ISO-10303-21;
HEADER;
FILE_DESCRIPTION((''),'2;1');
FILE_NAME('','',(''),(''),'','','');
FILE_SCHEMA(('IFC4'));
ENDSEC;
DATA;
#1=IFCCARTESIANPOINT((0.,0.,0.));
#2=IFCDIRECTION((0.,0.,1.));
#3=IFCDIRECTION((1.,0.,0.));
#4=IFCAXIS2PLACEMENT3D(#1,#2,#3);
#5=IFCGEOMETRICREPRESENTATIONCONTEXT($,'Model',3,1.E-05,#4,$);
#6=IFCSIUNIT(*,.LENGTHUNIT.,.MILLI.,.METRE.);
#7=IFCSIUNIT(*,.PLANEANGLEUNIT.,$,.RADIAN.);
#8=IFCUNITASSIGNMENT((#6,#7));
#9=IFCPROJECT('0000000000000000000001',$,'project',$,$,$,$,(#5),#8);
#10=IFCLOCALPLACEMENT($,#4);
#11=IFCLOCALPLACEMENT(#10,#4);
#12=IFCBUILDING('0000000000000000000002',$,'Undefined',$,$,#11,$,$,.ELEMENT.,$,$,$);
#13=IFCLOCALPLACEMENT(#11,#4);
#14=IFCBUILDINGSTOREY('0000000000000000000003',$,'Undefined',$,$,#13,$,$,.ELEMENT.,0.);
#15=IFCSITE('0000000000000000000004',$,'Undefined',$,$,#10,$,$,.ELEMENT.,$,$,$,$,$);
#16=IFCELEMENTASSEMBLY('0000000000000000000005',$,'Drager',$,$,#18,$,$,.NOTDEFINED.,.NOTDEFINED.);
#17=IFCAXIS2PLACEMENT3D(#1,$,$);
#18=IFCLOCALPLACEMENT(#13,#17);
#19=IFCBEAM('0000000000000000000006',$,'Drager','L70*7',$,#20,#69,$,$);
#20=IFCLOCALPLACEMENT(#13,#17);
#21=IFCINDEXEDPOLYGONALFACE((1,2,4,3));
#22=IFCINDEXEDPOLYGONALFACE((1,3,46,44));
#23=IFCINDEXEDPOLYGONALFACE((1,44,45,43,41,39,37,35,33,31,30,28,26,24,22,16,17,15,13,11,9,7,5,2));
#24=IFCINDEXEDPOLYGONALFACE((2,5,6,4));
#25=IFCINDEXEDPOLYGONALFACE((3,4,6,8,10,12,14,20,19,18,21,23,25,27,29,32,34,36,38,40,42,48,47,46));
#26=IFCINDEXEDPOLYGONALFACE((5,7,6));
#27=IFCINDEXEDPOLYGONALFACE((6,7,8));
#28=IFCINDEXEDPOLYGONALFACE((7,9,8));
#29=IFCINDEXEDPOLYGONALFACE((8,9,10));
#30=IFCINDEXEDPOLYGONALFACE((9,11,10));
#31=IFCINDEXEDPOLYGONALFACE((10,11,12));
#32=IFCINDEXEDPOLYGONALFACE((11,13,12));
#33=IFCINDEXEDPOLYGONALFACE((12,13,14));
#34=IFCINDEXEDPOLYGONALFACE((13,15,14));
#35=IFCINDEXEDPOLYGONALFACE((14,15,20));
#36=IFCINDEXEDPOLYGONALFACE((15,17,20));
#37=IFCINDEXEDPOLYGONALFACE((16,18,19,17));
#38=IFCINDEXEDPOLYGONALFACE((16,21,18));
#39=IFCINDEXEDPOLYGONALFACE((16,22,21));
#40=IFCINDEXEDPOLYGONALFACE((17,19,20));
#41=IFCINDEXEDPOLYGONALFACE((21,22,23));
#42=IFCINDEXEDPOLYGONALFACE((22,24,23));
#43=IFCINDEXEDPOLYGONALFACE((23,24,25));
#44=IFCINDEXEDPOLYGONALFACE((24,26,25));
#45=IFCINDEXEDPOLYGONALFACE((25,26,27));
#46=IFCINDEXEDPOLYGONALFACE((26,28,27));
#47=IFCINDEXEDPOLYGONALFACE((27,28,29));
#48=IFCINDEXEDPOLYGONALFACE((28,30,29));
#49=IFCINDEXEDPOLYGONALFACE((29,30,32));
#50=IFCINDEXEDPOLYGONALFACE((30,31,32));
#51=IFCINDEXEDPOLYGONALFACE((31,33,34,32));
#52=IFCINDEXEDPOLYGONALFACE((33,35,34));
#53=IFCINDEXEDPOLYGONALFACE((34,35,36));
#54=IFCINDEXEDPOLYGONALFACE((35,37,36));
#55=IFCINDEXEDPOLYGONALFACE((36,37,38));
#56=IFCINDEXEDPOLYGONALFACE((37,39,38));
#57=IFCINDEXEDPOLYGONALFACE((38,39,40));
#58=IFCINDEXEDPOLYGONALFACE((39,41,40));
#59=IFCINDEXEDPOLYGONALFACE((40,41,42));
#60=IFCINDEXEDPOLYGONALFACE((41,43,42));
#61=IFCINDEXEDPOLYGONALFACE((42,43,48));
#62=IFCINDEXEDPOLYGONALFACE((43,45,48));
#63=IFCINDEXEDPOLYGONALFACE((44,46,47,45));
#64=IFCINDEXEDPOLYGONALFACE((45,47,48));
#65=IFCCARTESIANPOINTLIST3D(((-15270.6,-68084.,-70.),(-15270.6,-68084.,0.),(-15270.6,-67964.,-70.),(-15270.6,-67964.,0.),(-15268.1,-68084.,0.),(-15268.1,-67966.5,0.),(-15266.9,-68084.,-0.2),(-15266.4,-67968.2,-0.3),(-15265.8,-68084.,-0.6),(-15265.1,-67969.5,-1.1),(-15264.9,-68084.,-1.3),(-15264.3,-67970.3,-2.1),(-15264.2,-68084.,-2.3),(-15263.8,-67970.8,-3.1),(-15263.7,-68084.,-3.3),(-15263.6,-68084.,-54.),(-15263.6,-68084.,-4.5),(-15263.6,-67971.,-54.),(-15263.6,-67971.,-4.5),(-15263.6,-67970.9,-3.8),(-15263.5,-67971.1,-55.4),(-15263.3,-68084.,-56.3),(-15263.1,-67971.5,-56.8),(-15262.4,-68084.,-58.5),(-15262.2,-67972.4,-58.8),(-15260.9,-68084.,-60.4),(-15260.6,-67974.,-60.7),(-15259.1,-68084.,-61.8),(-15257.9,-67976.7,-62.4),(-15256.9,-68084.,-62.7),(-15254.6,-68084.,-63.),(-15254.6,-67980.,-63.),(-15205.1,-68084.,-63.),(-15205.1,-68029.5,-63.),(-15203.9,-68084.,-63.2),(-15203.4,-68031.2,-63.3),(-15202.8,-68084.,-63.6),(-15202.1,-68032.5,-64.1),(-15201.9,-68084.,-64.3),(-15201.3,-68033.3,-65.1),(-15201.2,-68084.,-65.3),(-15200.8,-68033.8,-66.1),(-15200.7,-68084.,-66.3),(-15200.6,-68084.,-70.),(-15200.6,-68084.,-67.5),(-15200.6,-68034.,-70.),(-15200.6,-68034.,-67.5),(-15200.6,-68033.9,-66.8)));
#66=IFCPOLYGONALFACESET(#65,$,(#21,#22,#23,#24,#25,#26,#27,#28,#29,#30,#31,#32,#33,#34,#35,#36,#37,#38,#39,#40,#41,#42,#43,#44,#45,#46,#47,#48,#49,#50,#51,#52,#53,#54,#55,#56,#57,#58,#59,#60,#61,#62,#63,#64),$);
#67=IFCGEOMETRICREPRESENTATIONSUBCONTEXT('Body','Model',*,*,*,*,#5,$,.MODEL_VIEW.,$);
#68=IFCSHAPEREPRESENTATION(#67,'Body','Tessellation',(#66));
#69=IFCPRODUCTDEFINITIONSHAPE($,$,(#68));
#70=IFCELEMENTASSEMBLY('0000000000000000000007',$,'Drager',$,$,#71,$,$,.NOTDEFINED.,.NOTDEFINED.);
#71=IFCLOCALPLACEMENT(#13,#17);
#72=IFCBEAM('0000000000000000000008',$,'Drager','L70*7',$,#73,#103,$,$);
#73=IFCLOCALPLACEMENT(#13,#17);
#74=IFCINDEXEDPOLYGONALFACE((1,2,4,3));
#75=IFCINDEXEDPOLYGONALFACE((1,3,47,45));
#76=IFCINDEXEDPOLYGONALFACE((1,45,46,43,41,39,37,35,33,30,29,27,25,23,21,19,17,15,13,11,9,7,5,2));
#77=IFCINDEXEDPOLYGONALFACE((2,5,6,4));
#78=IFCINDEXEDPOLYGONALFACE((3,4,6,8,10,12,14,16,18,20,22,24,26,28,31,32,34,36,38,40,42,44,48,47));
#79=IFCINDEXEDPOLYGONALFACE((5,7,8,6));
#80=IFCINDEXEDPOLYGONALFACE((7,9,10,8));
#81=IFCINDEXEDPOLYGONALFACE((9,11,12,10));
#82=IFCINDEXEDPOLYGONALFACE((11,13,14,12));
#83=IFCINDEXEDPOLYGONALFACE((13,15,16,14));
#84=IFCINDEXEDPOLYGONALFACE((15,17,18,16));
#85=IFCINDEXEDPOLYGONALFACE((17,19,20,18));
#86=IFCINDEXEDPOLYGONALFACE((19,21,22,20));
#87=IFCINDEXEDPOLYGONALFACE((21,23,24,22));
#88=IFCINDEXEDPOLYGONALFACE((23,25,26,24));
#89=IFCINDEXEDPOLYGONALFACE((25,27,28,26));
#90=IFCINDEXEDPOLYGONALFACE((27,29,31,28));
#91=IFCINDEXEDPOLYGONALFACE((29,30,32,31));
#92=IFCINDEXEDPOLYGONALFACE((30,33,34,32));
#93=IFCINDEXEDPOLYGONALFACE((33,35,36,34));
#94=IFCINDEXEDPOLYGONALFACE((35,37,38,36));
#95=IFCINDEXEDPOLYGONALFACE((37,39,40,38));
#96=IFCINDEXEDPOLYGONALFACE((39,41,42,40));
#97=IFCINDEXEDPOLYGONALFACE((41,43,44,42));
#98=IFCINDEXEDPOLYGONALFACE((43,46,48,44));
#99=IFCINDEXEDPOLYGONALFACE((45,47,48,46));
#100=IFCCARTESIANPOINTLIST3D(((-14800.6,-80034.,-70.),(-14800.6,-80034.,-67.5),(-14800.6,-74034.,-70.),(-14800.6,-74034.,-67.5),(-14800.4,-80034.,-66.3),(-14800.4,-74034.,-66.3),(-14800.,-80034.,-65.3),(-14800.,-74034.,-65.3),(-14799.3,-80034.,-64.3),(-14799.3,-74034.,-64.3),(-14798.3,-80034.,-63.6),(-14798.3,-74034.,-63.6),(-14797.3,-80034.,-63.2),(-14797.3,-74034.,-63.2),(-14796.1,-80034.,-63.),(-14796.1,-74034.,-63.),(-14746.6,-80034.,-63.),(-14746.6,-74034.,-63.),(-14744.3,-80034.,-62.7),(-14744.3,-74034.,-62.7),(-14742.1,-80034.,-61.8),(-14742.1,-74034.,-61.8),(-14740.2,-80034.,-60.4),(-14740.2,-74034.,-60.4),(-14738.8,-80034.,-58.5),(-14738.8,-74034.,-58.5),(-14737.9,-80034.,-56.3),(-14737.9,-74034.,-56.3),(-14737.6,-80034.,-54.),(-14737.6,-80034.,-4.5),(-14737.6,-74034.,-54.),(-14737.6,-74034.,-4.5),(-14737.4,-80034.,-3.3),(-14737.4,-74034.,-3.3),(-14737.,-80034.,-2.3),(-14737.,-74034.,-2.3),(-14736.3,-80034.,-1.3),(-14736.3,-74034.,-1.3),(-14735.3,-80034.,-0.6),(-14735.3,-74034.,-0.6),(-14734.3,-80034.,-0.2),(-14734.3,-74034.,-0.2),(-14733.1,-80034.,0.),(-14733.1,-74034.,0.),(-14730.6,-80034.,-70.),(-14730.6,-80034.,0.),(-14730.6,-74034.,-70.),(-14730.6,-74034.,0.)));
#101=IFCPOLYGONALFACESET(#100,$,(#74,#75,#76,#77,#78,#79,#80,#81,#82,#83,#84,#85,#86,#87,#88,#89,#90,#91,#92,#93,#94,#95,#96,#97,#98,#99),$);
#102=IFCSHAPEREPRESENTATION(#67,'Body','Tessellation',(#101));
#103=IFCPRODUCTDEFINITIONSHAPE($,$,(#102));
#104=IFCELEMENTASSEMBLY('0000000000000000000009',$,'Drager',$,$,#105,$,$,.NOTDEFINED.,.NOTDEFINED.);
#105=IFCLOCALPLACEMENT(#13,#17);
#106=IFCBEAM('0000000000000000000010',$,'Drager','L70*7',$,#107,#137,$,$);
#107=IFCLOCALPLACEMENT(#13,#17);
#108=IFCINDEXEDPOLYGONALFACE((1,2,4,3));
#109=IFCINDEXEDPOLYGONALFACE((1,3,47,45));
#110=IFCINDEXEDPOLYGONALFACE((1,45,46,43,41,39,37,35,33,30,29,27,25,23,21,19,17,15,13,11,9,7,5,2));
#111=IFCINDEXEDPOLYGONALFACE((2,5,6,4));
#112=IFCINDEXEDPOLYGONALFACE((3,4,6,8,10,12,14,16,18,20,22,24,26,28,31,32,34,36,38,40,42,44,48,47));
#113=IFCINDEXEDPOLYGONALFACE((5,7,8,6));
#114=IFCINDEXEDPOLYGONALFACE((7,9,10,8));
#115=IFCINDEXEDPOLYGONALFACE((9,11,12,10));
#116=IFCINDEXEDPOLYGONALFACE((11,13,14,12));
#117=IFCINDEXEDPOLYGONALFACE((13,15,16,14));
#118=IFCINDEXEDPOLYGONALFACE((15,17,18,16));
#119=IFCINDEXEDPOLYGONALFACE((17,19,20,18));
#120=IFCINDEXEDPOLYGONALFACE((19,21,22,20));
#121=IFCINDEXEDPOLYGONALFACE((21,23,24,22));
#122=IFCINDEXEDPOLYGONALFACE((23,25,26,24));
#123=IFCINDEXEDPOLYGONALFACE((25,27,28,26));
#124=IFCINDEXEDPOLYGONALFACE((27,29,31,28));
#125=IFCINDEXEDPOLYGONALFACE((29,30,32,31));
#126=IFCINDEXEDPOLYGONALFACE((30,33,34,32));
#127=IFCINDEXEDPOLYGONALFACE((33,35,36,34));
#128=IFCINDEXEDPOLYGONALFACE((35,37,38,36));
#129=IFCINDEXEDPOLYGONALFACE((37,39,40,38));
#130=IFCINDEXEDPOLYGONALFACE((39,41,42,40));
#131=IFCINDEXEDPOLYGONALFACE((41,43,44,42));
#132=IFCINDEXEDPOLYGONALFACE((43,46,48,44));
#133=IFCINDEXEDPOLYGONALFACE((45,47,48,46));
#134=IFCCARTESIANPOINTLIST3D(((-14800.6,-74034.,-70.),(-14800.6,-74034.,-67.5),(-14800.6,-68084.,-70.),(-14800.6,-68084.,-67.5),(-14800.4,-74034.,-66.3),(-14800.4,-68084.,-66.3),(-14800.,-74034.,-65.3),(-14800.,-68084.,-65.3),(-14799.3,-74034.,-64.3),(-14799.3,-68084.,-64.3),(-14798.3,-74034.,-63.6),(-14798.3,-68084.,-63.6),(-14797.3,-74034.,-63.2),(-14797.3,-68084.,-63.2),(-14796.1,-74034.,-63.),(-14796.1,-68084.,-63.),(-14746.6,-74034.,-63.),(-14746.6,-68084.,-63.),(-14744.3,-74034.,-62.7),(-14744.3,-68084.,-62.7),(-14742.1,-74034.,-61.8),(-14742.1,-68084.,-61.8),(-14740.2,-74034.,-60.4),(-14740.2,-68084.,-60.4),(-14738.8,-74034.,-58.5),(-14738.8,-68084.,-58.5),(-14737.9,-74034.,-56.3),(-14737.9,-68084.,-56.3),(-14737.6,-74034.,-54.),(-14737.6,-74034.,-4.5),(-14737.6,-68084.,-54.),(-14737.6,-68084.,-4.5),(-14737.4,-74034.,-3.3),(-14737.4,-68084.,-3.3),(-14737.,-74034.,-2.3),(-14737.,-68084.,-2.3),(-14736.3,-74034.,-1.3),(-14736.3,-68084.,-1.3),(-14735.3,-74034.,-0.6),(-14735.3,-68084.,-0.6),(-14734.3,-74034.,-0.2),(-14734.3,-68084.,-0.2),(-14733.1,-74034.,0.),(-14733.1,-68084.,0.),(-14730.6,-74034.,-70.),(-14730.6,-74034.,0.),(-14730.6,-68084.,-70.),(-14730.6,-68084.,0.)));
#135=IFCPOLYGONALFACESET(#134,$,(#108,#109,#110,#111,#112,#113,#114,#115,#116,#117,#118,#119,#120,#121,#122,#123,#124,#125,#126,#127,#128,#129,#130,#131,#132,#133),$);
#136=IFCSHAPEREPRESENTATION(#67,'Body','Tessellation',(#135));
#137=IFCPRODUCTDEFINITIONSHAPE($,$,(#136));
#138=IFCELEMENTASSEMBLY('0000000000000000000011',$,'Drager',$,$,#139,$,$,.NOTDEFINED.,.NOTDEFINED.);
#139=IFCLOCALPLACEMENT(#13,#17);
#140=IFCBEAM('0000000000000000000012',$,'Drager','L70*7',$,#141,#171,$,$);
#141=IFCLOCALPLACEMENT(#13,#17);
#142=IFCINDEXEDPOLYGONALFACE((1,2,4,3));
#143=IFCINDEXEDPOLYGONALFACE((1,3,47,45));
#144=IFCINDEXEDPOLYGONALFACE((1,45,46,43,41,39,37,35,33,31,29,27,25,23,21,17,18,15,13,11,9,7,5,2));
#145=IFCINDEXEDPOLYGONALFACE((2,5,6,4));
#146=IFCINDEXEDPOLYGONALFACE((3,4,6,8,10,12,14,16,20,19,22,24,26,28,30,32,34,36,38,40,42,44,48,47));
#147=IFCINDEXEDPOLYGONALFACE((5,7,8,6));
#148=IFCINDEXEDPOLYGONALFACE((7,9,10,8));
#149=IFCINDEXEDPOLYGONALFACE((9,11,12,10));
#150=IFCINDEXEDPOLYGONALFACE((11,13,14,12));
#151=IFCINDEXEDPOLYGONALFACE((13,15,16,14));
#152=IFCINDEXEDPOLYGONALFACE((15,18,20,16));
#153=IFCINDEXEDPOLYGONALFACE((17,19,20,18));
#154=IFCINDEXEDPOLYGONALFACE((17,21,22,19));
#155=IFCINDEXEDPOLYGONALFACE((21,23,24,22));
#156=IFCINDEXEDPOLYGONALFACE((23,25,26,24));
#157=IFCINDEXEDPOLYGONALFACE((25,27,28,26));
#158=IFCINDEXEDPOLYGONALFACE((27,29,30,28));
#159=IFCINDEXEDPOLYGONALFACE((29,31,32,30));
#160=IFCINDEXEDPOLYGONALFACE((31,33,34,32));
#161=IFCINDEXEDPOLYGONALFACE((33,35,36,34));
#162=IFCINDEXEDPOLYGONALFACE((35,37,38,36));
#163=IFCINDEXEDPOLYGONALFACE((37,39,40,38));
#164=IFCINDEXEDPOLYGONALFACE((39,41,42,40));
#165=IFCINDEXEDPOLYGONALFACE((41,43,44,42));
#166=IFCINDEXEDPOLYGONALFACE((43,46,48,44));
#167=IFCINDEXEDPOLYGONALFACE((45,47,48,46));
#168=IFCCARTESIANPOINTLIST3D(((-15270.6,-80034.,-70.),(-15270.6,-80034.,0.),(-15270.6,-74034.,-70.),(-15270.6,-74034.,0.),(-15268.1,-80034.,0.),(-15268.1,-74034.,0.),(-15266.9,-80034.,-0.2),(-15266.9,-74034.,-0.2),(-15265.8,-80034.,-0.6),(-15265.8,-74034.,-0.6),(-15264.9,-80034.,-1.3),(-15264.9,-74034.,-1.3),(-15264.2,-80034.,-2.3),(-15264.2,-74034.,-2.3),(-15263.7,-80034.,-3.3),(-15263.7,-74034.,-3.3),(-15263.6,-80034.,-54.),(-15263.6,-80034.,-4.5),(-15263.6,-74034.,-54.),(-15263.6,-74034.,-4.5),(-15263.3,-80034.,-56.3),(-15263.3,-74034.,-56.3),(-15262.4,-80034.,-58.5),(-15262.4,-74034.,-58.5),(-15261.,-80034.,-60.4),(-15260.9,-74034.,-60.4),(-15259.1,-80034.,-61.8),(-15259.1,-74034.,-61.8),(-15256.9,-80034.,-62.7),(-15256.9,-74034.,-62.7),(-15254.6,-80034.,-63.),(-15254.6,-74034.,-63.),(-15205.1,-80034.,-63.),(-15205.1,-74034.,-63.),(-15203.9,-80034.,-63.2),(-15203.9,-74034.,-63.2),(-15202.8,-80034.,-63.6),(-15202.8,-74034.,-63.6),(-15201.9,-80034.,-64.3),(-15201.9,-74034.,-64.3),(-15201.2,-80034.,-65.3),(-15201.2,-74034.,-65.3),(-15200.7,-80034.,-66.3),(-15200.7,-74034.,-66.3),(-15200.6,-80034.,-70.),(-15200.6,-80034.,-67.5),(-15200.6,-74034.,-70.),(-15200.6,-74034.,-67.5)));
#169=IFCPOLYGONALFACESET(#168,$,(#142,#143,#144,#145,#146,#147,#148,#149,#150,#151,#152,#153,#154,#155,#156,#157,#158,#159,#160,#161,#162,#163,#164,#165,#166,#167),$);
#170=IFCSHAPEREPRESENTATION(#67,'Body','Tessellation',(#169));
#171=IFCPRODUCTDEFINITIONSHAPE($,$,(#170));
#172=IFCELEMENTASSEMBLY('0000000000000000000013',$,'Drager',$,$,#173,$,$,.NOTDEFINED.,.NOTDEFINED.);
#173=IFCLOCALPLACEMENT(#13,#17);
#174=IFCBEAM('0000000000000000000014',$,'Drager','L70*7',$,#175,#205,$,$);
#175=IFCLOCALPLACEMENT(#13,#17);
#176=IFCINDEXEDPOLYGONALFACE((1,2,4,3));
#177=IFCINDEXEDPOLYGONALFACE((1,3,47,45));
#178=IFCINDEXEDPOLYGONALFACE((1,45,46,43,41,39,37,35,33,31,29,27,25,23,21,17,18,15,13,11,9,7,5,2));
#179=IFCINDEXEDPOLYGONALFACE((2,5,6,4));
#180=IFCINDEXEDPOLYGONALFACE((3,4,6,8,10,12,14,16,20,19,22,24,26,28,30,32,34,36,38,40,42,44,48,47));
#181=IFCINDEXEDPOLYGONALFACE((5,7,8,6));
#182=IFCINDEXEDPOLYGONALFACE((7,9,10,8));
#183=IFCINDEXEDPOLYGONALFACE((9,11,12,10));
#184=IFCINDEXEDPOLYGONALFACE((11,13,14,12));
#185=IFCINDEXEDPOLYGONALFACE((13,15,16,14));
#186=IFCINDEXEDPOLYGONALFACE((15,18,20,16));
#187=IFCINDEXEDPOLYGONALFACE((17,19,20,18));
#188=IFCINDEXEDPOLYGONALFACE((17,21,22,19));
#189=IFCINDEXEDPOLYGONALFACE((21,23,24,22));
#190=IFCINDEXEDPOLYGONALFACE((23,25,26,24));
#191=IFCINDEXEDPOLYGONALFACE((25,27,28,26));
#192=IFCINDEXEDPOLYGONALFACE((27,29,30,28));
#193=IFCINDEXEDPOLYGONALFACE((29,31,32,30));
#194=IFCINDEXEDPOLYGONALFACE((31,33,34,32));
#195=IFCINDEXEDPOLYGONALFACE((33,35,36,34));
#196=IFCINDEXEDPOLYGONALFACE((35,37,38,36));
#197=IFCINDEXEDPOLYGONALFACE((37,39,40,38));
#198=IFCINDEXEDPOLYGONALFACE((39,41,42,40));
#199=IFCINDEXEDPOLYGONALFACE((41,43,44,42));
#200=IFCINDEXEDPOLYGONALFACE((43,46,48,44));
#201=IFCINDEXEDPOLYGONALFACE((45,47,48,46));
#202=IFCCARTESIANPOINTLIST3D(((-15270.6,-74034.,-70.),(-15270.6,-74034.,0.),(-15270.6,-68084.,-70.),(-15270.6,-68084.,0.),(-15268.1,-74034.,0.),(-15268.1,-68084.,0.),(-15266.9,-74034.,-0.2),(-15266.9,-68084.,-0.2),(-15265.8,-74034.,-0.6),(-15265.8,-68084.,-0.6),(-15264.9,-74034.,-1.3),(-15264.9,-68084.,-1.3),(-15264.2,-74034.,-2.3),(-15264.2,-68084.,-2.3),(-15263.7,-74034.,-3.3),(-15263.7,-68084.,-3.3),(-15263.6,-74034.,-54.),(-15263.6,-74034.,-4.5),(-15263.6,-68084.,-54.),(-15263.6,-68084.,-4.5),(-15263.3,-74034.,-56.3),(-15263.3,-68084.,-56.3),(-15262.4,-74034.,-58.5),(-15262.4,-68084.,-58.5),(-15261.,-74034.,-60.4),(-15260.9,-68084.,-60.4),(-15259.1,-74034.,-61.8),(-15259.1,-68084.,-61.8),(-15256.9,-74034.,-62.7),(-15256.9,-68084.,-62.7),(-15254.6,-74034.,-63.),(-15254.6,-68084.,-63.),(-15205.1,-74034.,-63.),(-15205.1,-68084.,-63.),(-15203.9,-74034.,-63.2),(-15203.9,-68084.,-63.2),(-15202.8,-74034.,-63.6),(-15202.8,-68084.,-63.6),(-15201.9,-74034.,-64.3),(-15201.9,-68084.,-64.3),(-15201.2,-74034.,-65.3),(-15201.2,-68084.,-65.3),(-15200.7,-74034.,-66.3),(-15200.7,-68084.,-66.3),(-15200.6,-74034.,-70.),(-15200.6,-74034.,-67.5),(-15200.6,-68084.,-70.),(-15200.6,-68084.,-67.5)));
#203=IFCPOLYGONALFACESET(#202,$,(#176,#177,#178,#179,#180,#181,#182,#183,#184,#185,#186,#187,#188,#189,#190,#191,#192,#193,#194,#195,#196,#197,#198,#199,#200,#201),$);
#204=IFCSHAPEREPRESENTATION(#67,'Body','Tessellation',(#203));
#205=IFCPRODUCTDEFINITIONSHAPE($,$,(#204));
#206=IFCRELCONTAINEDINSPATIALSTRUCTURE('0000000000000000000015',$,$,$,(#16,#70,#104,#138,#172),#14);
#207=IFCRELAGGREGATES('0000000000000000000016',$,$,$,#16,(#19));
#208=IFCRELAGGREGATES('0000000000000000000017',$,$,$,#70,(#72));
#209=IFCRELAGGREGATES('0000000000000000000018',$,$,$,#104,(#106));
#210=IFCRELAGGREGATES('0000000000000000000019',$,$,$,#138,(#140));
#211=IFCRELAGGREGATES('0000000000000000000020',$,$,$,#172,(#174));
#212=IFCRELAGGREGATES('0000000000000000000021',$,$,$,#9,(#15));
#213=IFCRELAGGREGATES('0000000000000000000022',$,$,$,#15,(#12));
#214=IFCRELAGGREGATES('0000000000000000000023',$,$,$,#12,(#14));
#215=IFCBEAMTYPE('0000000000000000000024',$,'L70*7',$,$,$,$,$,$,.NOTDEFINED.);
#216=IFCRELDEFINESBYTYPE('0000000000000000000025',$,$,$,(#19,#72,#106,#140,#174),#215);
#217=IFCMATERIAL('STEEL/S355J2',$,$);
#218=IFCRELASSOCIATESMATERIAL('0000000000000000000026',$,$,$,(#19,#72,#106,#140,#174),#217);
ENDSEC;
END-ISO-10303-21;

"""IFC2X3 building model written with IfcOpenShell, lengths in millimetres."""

from ifc_helpers import new_model, si_unit, frame, origin_with_axes, origin_2d_with_axis, place, context, subcontext, project, spatial, l_section, extrude, clip, halfspace, material, type_object, element, aggregate, save


model = new_model("IFC2X3")

# Units and contexts
model_context = context("Model", 3, precision=1e-05, world=origin_with_axes())
body_context = subcontext(model_context, "Body", "Model", "MODEL_VIEW")
ifc_project = project(units=[si_unit("LENGTHUNIT", "METRE", prefix="MILLI"), si_unit("PLANEANGLEUNIT", "RADIAN")], contexts=[model_context])

# Site, building, storey
site_placement = place(None, origin_with_axes())
site = spatial("IfcSite", under=ifc_project, at=site_placement, Name="Undefined", CompositionType="ELEMENT")
building_placement = place(site_placement, origin_with_axes())
building = spatial("IfcBuilding", under=site, at=building_placement, Name="Undefined", CompositionType="ELEMENT")
storey_placement = place(building_placement, origin_with_axes())
storey = spatial("IfcBuildingStorey", under=building, at=storey_placement, Name="Undefined", CompositionType="ELEMENT", Elevation=0.0)

# Shared definitions
ifc_material = material(Name="STEEL/S355J2")
beam_type = type_object("IfcBeamType", Name="L70*7", PredefinedType="NOTDEFINED")

# Element assembly, beam
assembly_1_placement = place(storey_placement, origin_with_axes())
assembly_1 = element("IfcElementAssembly", 1, at=assembly_1_placement, inside=storey, Name="Drager", AssemblyPlace="NOTDEFINED", PredefinedType="NOTDEFINED")
beam_1_placement = place(assembly_1_placement, frame((-15235.6, -68084.0, -35.0), z_axis=(0.0, 0.0, 1.0), x_axis=(0.0, 1.0, 0.0)))
beam_1 = element("IfcBeam", 2, at=beam_1_placement, type_object=beam_type, material=ifc_material, Name="Drager", Description="L70*7", context=body_context, shape_type="Clipping", body=[
    clip(extrude(l_section(Depth=70.0, Width=70.0, Thickness=7.0, FilletRadius=9.0, EdgeRadius=4.5, at=origin_2d_with_axis()), frame((120.3, 0.0, 0.0), z_axis=(-1.0, 0.0, 0.0), x_axis=(0.0, -1.0, 0.0)), (0.0, 0.0, 1.0), 120.3), halfspace(frame((50.0, -35.0, 35.0), z_axis=(0.707107, -0.707107, 0.0), x_axis=(0.0, 0.0, 1.0)), False)),
])
aggregate(assembly_1, [beam_1])

# Element assemblies, beams
assembly_2_placement = place(storey_placement, origin_with_axes())
assembly_2 = element("IfcElementAssembly", 3, at=assembly_2_placement, inside=storey, Name="Drager", AssemblyPlace="NOTDEFINED", PredefinedType="NOTDEFINED")
beam_2_placement = place(assembly_2_placement, frame((-14765.6, -74034.0, -35.0), z_axis=(0.0, 0.0, 1.0), x_axis=(0.0, -1.0, 0.0)))
beam_2 = element("IfcBeam", 4, at=beam_2_placement, type_object=beam_type, material=ifc_material, Name="Drager", Description="L70*7", context=body_context, shape_type="SweptSolid", body=[
    extrude(l_section(Depth=70.0, Width=70.0, Thickness=7.0, FilletRadius=9.0, EdgeRadius=4.5, at=origin_2d_with_axis()), frame((6000.0, 0.0, 0.0), z_axis=(-1.0, 0.0, 0.0), x_axis=(0.0, -1.0, 0.0)), (0.0, 0.0, 1.0), 6000.0),
])
aggregate(assembly_2, [beam_2])
assembly_3_placement = place(storey_placement, origin_with_axes())
assembly_3 = element("IfcElementAssembly", 5, at=assembly_3_placement, inside=storey, Name="Drager", AssemblyPlace="NOTDEFINED", PredefinedType="NOTDEFINED")
beam_3_placement = place(assembly_3_placement, frame((-14765.6, -68084.0, -35.0), z_axis=(0.0, 0.0, 1.0), x_axis=(0.0, -1.0, 0.0)))
beam_3 = element("IfcBeam", 6, at=beam_3_placement, type_object=beam_type, material=ifc_material, Name="Drager", Description="L70*7", context=body_context, shape_type="SweptSolid", body=[
    extrude(l_section(Depth=70.0, Width=70.0, Thickness=7.0, FilletRadius=9.0, EdgeRadius=4.5, at=origin_2d_with_axis()), frame((5950.0, 0.0, 0.0), z_axis=(-1.0, 0.0, 0.0), x_axis=(0.0, -1.0, 0.0)), (0.0, 0.0, 1.0), 5950.0),
])
aggregate(assembly_3, [beam_3])
assembly_4_placement = place(storey_placement, origin_with_axes())
assembly_4 = element("IfcElementAssembly", 7, at=assembly_4_placement, inside=storey, Name="Drager", AssemblyPlace="NOTDEFINED", PredefinedType="NOTDEFINED")
beam_4_placement = place(assembly_4_placement, frame((-15235.6, -80034.0, -35.0), z_axis=(0.0, 0.0, 1.0), x_axis=(0.0, 1.0, 0.0)))
beam_4 = element("IfcBeam", 8, at=beam_4_placement, type_object=beam_type, material=ifc_material, Name="Drager", Description="L70*7", context=body_context, shape_type="SweptSolid", body=[
    extrude(l_section(Depth=70.0, Width=70.0, Thickness=7.0, FilletRadius=9.0, EdgeRadius=4.5, at=origin_2d_with_axis()), frame((6000.0, 0.0, 0.0), z_axis=(-1.0, 0.0, 0.0), x_axis=(0.0, -1.0, 0.0)), (0.0, 0.0, 1.0), 6000.0),
])
aggregate(assembly_4, [beam_4])
assembly_5_placement = place(storey_placement, origin_with_axes())
assembly_5 = element("IfcElementAssembly", 9, at=assembly_5_placement, inside=storey, Name="Drager", AssemblyPlace="NOTDEFINED", PredefinedType="NOTDEFINED")
beam_5_placement = place(assembly_5_placement, frame((-15235.6, -74034.0, -35.0), z_axis=(0.0, 0.0, 1.0), x_axis=(0.0, 1.0, 0.0)))
beam_5 = element("IfcBeam", 10, at=beam_5_placement, type_object=beam_type, material=ifc_material, Name="Drager", Description="L70*7", context=body_context, shape_type="SweptSolid", body=[
    extrude(l_section(Depth=70.0, Width=70.0, Thickness=7.0, FilletRadius=9.0, EdgeRadius=4.5, at=origin_2d_with_axis()), frame((5950.0, 0.0, 0.0), z_axis=(-1.0, 0.0, 0.0), x_axis=(0.0, -1.0, 0.0)), (0.0, 0.0, 1.0), 5950.0),
])
aggregate(assembly_5, [beam_5])

save(model, "model.ifc")
